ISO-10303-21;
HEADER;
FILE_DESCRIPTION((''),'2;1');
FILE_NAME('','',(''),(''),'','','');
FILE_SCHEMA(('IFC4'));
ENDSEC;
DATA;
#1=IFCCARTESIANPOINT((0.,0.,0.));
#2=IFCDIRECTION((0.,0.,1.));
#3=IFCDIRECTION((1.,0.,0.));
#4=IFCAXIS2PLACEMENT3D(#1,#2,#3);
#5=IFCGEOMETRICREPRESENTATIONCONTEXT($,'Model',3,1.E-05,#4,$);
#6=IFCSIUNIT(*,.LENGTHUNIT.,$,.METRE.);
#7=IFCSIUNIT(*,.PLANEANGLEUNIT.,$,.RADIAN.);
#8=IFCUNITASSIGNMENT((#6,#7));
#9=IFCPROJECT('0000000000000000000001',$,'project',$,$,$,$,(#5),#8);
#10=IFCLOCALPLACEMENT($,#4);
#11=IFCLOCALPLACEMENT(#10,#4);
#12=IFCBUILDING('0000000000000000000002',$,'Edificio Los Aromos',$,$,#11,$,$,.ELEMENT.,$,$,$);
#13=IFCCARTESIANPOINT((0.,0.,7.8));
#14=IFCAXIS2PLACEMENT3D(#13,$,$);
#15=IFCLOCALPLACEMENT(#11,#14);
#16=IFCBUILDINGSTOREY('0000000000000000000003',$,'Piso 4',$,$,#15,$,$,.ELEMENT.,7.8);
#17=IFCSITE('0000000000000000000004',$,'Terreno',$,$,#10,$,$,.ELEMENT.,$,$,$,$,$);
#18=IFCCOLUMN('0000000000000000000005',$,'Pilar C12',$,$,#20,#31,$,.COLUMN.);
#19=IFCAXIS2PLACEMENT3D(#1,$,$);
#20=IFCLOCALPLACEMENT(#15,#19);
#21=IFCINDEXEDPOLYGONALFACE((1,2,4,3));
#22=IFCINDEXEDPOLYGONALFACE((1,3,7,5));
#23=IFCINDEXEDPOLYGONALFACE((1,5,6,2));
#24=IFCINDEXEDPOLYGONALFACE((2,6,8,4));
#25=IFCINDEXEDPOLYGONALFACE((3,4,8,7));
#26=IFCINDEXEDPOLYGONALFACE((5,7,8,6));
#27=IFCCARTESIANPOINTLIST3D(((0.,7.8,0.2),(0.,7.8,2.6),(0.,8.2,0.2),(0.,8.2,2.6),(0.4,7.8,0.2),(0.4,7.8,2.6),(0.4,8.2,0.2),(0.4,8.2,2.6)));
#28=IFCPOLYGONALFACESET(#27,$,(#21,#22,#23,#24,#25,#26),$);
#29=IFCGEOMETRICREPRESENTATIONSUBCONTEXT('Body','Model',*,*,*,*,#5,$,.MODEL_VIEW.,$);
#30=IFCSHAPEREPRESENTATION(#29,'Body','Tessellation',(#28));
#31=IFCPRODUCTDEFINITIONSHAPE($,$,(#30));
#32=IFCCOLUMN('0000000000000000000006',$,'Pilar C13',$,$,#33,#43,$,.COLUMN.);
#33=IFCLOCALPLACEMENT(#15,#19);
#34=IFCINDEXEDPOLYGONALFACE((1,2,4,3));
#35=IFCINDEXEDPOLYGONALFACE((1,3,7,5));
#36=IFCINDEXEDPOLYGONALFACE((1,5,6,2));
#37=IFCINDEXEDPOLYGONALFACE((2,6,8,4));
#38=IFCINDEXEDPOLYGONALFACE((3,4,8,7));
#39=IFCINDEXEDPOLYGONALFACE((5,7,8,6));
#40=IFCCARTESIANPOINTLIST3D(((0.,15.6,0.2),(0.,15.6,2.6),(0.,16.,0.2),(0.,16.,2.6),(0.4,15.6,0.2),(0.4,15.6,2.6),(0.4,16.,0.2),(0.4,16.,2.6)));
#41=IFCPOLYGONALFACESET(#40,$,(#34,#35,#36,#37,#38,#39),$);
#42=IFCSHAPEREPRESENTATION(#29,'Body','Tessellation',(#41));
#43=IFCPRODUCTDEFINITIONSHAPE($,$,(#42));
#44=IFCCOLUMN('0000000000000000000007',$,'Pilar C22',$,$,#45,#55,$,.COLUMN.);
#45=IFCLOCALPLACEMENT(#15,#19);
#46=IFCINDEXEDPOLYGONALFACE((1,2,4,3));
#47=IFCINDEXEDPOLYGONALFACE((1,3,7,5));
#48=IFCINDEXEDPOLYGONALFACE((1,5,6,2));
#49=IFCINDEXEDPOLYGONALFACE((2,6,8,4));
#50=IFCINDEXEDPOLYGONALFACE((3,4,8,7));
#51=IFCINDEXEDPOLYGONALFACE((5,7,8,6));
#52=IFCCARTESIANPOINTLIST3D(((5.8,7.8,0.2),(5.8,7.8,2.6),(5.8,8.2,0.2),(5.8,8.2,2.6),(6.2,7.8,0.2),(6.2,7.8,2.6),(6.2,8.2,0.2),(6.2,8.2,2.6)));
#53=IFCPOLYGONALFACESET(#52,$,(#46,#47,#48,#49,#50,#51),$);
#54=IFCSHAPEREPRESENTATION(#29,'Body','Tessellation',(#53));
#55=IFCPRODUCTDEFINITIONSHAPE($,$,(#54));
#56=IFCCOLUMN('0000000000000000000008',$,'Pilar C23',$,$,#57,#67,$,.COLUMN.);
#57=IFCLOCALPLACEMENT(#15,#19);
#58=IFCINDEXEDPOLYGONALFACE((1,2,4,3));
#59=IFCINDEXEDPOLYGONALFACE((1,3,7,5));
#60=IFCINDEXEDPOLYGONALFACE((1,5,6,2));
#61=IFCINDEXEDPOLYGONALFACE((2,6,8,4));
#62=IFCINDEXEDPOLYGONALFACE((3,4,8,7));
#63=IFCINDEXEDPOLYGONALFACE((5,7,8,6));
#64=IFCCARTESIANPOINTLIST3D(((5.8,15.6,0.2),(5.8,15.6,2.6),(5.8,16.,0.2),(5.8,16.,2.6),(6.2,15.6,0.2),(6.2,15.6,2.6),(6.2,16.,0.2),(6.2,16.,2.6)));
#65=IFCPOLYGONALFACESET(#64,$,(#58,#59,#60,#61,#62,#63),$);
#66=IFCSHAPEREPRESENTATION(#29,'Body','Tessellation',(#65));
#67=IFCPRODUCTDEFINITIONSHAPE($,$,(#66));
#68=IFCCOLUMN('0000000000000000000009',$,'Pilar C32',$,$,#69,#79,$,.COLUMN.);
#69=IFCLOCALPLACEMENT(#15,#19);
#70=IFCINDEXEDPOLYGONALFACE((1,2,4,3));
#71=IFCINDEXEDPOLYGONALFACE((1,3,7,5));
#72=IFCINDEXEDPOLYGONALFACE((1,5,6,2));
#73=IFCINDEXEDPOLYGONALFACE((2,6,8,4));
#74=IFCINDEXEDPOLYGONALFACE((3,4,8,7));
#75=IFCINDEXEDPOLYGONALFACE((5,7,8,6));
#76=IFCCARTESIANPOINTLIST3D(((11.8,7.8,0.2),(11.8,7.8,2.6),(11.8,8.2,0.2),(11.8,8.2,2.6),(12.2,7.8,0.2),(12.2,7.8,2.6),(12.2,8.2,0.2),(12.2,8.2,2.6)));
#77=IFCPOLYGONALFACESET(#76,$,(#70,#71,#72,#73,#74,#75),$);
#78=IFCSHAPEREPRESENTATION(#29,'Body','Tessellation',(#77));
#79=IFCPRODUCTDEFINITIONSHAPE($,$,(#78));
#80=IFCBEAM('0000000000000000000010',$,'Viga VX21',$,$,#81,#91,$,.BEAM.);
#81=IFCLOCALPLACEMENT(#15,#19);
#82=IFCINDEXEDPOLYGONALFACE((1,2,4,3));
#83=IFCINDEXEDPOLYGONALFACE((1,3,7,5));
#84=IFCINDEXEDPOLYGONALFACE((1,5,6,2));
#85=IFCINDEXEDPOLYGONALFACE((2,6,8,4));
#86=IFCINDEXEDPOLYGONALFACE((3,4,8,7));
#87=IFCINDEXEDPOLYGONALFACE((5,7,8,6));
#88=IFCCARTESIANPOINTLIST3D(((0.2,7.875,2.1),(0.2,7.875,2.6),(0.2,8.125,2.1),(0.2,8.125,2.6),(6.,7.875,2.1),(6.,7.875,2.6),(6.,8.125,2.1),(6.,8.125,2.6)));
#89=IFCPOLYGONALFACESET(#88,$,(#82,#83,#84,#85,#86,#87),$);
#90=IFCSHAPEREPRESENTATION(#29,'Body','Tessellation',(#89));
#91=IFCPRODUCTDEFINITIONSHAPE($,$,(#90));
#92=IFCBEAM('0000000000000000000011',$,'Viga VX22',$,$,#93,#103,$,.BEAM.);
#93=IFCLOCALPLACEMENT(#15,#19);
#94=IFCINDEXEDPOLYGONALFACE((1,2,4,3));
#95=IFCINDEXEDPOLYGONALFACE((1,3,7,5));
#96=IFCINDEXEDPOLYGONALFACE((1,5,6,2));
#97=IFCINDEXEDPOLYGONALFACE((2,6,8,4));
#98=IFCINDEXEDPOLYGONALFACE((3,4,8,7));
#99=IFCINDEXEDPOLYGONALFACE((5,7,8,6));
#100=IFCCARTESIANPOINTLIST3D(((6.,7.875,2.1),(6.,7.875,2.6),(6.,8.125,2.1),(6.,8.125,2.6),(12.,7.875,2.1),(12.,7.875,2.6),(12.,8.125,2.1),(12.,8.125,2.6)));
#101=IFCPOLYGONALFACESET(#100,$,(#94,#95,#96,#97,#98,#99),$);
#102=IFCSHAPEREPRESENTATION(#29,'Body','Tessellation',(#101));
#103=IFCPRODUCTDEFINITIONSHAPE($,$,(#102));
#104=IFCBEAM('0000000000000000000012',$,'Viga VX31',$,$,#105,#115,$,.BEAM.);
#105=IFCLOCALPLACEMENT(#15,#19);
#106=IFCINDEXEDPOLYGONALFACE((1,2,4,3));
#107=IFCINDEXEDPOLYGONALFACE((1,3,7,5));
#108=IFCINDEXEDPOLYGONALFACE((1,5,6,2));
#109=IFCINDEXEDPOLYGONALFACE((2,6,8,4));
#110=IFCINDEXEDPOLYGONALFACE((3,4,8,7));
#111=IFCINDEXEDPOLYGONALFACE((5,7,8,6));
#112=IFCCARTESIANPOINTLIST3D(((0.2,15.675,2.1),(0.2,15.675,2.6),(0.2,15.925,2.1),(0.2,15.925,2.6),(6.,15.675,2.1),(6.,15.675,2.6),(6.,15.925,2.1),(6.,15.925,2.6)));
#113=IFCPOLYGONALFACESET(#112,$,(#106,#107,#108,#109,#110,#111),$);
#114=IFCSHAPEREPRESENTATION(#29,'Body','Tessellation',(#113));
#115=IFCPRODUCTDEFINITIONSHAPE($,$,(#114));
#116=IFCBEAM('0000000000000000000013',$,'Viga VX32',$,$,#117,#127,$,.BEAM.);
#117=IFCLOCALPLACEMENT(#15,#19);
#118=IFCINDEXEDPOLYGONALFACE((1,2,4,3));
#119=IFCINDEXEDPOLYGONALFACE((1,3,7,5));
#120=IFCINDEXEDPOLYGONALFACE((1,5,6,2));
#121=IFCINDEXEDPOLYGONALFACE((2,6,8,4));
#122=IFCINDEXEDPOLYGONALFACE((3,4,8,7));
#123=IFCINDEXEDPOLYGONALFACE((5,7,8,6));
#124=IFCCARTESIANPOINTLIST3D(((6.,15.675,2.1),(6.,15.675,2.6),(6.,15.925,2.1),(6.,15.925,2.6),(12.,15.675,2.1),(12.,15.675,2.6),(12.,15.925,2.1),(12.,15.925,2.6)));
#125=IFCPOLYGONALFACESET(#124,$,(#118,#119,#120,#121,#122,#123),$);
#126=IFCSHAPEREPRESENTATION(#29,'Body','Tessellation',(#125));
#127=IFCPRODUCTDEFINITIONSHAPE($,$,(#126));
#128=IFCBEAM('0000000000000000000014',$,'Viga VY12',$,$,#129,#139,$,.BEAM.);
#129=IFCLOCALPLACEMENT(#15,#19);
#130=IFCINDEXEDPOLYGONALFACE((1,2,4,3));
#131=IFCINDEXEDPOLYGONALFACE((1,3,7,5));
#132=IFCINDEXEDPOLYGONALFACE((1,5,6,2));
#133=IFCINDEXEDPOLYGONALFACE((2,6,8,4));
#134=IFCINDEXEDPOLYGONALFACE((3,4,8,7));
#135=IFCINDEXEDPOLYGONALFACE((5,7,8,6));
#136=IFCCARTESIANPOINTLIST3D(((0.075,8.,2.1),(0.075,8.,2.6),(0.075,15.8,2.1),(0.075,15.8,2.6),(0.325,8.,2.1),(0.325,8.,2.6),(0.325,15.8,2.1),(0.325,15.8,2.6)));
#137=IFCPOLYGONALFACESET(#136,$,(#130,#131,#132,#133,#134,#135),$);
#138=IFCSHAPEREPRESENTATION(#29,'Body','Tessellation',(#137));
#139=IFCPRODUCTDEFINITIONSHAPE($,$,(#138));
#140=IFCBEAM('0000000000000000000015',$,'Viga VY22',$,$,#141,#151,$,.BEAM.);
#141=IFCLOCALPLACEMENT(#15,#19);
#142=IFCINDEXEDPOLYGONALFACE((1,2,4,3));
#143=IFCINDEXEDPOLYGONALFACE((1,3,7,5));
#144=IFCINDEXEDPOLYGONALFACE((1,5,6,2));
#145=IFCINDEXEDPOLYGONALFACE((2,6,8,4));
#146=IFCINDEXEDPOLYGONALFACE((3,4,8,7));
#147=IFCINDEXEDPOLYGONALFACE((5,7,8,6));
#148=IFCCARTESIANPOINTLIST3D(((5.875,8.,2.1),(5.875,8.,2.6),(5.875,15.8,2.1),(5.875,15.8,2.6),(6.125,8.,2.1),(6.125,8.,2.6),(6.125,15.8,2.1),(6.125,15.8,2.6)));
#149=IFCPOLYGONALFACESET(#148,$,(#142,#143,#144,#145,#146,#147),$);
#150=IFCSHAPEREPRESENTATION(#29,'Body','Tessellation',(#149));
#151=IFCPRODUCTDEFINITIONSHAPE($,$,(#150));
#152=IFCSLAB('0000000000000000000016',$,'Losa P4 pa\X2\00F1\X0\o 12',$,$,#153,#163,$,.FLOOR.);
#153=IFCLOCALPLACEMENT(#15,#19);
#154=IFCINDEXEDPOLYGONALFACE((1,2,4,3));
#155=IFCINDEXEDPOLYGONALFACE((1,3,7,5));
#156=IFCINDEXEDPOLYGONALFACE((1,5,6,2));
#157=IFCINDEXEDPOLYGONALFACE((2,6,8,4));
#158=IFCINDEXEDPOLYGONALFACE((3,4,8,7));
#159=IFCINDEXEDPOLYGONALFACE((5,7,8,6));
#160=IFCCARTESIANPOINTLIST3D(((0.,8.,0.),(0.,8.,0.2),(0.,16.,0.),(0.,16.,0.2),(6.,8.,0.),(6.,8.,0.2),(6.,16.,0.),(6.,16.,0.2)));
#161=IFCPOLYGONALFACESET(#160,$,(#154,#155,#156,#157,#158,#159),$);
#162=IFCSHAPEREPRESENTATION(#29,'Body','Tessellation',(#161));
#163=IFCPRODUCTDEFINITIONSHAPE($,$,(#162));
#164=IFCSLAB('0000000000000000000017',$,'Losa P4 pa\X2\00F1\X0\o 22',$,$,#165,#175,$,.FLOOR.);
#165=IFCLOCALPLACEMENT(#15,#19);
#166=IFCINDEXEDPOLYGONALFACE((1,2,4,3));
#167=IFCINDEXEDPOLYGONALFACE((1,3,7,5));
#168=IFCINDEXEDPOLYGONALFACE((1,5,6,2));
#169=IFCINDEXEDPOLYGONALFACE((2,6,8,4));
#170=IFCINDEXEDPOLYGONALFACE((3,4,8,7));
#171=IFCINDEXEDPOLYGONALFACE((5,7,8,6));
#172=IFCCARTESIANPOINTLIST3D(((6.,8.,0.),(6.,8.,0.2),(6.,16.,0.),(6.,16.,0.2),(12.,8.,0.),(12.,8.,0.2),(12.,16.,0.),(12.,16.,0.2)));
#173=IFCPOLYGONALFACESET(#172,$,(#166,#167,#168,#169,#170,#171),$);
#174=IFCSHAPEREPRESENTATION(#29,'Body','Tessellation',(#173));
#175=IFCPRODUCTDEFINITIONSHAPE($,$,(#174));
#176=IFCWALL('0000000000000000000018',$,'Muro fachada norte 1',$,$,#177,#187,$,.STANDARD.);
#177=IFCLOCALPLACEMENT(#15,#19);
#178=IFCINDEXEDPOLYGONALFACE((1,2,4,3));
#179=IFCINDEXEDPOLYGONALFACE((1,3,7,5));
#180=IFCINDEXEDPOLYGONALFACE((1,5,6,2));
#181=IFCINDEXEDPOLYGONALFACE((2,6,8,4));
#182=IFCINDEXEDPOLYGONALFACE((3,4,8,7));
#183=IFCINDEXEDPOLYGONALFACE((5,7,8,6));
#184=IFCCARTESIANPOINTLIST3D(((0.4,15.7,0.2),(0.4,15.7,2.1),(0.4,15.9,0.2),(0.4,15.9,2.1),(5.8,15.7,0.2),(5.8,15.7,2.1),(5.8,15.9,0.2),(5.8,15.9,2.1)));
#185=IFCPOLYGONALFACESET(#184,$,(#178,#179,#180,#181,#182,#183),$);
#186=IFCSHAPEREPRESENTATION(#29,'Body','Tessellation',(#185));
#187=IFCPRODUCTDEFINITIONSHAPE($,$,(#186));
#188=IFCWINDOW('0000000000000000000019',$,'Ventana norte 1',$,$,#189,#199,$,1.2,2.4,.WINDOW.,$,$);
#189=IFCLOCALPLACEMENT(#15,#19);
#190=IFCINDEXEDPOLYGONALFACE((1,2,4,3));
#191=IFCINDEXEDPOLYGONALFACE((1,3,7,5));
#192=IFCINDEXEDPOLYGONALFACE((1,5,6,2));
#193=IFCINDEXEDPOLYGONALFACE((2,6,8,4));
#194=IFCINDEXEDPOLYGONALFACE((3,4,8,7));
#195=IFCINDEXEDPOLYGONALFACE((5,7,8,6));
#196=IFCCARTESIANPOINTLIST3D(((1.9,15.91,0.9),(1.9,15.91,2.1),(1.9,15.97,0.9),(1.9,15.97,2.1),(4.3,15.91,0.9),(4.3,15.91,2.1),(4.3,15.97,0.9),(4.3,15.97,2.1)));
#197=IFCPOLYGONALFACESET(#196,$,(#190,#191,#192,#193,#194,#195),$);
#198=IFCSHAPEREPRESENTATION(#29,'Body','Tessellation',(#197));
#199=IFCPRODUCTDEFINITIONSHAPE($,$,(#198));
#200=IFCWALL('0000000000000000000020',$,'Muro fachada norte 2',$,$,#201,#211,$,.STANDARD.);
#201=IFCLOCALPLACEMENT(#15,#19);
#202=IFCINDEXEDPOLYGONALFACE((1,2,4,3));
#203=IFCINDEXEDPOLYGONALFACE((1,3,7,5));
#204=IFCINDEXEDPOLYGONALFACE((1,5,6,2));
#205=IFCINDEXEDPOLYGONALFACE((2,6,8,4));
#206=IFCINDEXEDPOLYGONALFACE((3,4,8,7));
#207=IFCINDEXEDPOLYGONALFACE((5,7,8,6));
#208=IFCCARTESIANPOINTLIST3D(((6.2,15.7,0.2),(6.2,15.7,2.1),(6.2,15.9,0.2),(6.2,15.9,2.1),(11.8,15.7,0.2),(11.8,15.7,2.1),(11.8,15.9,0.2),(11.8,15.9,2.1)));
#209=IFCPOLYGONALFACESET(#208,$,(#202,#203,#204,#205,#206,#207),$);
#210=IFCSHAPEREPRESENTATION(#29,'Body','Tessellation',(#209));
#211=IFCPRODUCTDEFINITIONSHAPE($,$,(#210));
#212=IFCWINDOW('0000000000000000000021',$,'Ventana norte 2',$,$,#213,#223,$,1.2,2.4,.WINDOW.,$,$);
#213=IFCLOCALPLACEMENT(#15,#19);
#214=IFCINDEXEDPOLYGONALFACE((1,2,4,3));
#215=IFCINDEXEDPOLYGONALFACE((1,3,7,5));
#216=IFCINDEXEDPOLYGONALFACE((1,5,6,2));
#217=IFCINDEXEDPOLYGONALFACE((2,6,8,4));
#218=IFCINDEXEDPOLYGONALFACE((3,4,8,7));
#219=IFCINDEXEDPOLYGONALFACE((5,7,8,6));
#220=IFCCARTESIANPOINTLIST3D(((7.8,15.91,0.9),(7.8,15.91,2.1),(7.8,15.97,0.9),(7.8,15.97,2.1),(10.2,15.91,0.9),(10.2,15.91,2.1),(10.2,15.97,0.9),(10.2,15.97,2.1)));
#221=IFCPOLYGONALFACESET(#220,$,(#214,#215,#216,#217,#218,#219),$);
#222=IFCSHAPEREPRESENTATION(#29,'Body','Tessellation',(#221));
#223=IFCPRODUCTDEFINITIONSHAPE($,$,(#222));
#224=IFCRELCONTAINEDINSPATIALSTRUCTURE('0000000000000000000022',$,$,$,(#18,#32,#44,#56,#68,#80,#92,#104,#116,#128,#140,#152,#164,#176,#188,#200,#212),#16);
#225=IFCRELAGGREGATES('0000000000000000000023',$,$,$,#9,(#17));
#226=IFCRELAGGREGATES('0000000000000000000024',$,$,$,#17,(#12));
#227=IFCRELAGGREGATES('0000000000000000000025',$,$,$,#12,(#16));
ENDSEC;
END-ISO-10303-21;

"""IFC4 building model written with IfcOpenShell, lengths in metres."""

from ifc_helpers import new_model, si_unit, frame, frame_2d, origin_with_axes, place, context, subcontext, project, spatial, rectangle, extrude, element, save


model = new_model("IFC4")

# Units and contexts
model_context = context("Model", 3, precision=1e-05, world=origin_with_axes())
body_context = subcontext(model_context, "Body", "Model", "MODEL_VIEW")
ifc_project = project(units=[si_unit("LENGTHUNIT", "METRE"), si_unit("PLANEANGLEUNIT", "RADIAN")], contexts=[model_context])

# Site, building, storey
site_placement = place(None, origin_with_axes())
site = spatial("IfcSite", under=ifc_project, at=site_placement, Name="Terreno", CompositionType="ELEMENT")
building_placement = place(site_placement, origin_with_axes())
building = spatial("IfcBuilding", under=site, at=building_placement, Name="Edificio Los Aromos", CompositionType="ELEMENT")
storey_placement = place(building_placement, frame((0.0, 0.0, 7.8)))
storey = spatial("IfcBuildingStorey", under=building, at=storey_placement, Name="Piso 4", CompositionType="ELEMENT", Elevation=7.8)

# Columns
for number, where, name in (
    (1, (0.0, 7.8, 0.2), "Pilar C12"),
    (2, (0.0, 15.6, 0.2), "Pilar C13"),
    (3, (5.8, 7.8, 0.2), "Pilar C22"),
    (4, (5.8, 15.6, 0.2), "Pilar C23"),
    (5, (11.8, 7.8, 0.2), "Pilar C32"),
):
    element("IfcColumn", number, at=place(storey_placement, frame(where)), inside=storey, Name=name, PredefinedType="COLUMN", context=body_context, shape_type="SweptSolid", body=[
        extrude(rectangle(XDim=0.4, YDim=0.4, at=frame_2d((0.2, 0.2))), origin_with_axes(), (0.0, 0.0, 1.0), 2.4),
    ])

# Beams
beam_1_placement = place(storey_placement, frame((0.2, 7.875, 2.1)))
element("IfcBeam", 6, at=beam_1_placement, inside=storey, Name="Viga VX21", PredefinedType="BEAM", context=body_context, shape_type="SweptSolid", body=[
    extrude(rectangle(XDim=5.8, YDim=0.25, at=frame_2d((2.9, 0.125))), origin_with_axes(), (0.0, 0.0, 1.0), 0.5),
])
beam_2_placement = place(storey_placement, frame((6.0, 7.875, 2.1)))
element("IfcBeam", 7, at=beam_2_placement, inside=storey, Name="Viga VX22", PredefinedType="BEAM", context=body_context, shape_type="SweptSolid", body=[
    extrude(rectangle(XDim=6.0, YDim=0.25, at=frame_2d((3.0, 0.125))), origin_with_axes(), (0.0, 0.0, 1.0), 0.5),
])
beam_3_placement = place(storey_placement, frame((0.2, 15.675, 2.1)))
element("IfcBeam", 8, at=beam_3_placement, inside=storey, Name="Viga VX31", PredefinedType="BEAM", context=body_context, shape_type="SweptSolid", body=[
    extrude(rectangle(XDim=5.8, YDim=0.25, at=frame_2d((2.9, 0.125))), origin_with_axes(), (0.0, 0.0, 1.0), 0.5),
])
beam_4_placement = place(storey_placement, frame((6.0, 15.675, 2.1)))
element("IfcBeam", 9, at=beam_4_placement, inside=storey, Name="Viga VX32", PredefinedType="BEAM", context=body_context, shape_type="SweptSolid", body=[
    extrude(rectangle(XDim=6.0, YDim=0.25, at=frame_2d((3.0, 0.125))), origin_with_axes(), (0.0, 0.0, 1.0), 0.5),
])
for number, where, name in (
    (10, (0.075, 8.0, 2.1), "Viga VY12"),
    (11, (5.875, 8.0, 2.1), "Viga VY22"),
):
    element("IfcBeam", number, at=place(storey_placement, frame(where)), inside=storey, Name=name, PredefinedType="BEAM", context=body_context, shape_type="SweptSolid", body=[
        extrude(rectangle(XDim=0.25, YDim=7.8, at=frame_2d((0.125, 3.9))), origin_with_axes(), (0.0, 0.0, 1.0), 0.5),
    ])

# Slabs
for number, where, name in (
    (12, (0.0, 8.0, 0.0), "Losa P4 paño 12"),
    (13, (6.0, 8.0, 0.0), "Losa P4 paño 22"),
):
    element("IfcSlab", number, at=place(storey_placement, frame(where)), inside=storey, Name=name, PredefinedType="FLOOR", context=body_context, shape_type="SweptSolid", body=[
        extrude(rectangle(XDim=6.0, YDim=8.0, at=frame_2d((3.0, 4.0))), origin_with_axes(), (0.0, 0.0, 1.0), 0.2),
    ])

# Wall
wall_1_placement = place(storey_placement, frame((0.4, 15.7, 0.2)))
element("IfcWall", 14, at=wall_1_placement, inside=storey, Name="Muro fachada norte 1", PredefinedType="STANDARD", context=body_context, shape_type="SweptSolid", body=[
    extrude(rectangle(XDim=5.4, YDim=0.2, at=frame_2d((2.7, 0.1))), origin_with_axes(), (0.0, 0.0, 1.0), 1.9),
])

# Window
window_1_placement = place(storey_placement, frame((1.9, 15.91, 0.9)))
element("IfcWindow", 15, at=window_1_placement, inside=storey, Name="Ventana norte 1", OverallHeight=1.2, OverallWidth=2.4, PredefinedType="WINDOW", context=body_context, shape_type="SweptSolid", body=[
    extrude(rectangle(XDim=2.4, YDim=0.06, at=frame_2d((1.2, 0.03))), origin_with_axes(), (0.0, 0.0, 1.0), 1.2),
])

# Wall
wall_2_placement = place(storey_placement, frame((6.2, 15.7, 0.2)))
element("IfcWall", 16, at=wall_2_placement, inside=storey, Name="Muro fachada norte 2", PredefinedType="STANDARD", context=body_context, shape_type="SweptSolid", body=[
    extrude(rectangle(XDim=5.6, YDim=0.2, at=frame_2d((2.8, 0.1))), origin_with_axes(), (0.0, 0.0, 1.0), 1.9),
])

# Window
window_2_placement = place(storey_placement, frame((7.8, 15.91, 0.9)))
element("IfcWindow", 17, at=window_2_placement, inside=storey, Name="Ventana norte 2", OverallHeight=1.2, OverallWidth=2.4, PredefinedType="WINDOW", context=body_context, shape_type="SweptSolid", body=[
    extrude(rectangle(XDim=2.4, YDim=0.06, at=frame_2d((1.2, 0.03))), origin_with_axes(), (0.0, 0.0, 1.0), 1.2),
])

save(model, "model.ifc")
